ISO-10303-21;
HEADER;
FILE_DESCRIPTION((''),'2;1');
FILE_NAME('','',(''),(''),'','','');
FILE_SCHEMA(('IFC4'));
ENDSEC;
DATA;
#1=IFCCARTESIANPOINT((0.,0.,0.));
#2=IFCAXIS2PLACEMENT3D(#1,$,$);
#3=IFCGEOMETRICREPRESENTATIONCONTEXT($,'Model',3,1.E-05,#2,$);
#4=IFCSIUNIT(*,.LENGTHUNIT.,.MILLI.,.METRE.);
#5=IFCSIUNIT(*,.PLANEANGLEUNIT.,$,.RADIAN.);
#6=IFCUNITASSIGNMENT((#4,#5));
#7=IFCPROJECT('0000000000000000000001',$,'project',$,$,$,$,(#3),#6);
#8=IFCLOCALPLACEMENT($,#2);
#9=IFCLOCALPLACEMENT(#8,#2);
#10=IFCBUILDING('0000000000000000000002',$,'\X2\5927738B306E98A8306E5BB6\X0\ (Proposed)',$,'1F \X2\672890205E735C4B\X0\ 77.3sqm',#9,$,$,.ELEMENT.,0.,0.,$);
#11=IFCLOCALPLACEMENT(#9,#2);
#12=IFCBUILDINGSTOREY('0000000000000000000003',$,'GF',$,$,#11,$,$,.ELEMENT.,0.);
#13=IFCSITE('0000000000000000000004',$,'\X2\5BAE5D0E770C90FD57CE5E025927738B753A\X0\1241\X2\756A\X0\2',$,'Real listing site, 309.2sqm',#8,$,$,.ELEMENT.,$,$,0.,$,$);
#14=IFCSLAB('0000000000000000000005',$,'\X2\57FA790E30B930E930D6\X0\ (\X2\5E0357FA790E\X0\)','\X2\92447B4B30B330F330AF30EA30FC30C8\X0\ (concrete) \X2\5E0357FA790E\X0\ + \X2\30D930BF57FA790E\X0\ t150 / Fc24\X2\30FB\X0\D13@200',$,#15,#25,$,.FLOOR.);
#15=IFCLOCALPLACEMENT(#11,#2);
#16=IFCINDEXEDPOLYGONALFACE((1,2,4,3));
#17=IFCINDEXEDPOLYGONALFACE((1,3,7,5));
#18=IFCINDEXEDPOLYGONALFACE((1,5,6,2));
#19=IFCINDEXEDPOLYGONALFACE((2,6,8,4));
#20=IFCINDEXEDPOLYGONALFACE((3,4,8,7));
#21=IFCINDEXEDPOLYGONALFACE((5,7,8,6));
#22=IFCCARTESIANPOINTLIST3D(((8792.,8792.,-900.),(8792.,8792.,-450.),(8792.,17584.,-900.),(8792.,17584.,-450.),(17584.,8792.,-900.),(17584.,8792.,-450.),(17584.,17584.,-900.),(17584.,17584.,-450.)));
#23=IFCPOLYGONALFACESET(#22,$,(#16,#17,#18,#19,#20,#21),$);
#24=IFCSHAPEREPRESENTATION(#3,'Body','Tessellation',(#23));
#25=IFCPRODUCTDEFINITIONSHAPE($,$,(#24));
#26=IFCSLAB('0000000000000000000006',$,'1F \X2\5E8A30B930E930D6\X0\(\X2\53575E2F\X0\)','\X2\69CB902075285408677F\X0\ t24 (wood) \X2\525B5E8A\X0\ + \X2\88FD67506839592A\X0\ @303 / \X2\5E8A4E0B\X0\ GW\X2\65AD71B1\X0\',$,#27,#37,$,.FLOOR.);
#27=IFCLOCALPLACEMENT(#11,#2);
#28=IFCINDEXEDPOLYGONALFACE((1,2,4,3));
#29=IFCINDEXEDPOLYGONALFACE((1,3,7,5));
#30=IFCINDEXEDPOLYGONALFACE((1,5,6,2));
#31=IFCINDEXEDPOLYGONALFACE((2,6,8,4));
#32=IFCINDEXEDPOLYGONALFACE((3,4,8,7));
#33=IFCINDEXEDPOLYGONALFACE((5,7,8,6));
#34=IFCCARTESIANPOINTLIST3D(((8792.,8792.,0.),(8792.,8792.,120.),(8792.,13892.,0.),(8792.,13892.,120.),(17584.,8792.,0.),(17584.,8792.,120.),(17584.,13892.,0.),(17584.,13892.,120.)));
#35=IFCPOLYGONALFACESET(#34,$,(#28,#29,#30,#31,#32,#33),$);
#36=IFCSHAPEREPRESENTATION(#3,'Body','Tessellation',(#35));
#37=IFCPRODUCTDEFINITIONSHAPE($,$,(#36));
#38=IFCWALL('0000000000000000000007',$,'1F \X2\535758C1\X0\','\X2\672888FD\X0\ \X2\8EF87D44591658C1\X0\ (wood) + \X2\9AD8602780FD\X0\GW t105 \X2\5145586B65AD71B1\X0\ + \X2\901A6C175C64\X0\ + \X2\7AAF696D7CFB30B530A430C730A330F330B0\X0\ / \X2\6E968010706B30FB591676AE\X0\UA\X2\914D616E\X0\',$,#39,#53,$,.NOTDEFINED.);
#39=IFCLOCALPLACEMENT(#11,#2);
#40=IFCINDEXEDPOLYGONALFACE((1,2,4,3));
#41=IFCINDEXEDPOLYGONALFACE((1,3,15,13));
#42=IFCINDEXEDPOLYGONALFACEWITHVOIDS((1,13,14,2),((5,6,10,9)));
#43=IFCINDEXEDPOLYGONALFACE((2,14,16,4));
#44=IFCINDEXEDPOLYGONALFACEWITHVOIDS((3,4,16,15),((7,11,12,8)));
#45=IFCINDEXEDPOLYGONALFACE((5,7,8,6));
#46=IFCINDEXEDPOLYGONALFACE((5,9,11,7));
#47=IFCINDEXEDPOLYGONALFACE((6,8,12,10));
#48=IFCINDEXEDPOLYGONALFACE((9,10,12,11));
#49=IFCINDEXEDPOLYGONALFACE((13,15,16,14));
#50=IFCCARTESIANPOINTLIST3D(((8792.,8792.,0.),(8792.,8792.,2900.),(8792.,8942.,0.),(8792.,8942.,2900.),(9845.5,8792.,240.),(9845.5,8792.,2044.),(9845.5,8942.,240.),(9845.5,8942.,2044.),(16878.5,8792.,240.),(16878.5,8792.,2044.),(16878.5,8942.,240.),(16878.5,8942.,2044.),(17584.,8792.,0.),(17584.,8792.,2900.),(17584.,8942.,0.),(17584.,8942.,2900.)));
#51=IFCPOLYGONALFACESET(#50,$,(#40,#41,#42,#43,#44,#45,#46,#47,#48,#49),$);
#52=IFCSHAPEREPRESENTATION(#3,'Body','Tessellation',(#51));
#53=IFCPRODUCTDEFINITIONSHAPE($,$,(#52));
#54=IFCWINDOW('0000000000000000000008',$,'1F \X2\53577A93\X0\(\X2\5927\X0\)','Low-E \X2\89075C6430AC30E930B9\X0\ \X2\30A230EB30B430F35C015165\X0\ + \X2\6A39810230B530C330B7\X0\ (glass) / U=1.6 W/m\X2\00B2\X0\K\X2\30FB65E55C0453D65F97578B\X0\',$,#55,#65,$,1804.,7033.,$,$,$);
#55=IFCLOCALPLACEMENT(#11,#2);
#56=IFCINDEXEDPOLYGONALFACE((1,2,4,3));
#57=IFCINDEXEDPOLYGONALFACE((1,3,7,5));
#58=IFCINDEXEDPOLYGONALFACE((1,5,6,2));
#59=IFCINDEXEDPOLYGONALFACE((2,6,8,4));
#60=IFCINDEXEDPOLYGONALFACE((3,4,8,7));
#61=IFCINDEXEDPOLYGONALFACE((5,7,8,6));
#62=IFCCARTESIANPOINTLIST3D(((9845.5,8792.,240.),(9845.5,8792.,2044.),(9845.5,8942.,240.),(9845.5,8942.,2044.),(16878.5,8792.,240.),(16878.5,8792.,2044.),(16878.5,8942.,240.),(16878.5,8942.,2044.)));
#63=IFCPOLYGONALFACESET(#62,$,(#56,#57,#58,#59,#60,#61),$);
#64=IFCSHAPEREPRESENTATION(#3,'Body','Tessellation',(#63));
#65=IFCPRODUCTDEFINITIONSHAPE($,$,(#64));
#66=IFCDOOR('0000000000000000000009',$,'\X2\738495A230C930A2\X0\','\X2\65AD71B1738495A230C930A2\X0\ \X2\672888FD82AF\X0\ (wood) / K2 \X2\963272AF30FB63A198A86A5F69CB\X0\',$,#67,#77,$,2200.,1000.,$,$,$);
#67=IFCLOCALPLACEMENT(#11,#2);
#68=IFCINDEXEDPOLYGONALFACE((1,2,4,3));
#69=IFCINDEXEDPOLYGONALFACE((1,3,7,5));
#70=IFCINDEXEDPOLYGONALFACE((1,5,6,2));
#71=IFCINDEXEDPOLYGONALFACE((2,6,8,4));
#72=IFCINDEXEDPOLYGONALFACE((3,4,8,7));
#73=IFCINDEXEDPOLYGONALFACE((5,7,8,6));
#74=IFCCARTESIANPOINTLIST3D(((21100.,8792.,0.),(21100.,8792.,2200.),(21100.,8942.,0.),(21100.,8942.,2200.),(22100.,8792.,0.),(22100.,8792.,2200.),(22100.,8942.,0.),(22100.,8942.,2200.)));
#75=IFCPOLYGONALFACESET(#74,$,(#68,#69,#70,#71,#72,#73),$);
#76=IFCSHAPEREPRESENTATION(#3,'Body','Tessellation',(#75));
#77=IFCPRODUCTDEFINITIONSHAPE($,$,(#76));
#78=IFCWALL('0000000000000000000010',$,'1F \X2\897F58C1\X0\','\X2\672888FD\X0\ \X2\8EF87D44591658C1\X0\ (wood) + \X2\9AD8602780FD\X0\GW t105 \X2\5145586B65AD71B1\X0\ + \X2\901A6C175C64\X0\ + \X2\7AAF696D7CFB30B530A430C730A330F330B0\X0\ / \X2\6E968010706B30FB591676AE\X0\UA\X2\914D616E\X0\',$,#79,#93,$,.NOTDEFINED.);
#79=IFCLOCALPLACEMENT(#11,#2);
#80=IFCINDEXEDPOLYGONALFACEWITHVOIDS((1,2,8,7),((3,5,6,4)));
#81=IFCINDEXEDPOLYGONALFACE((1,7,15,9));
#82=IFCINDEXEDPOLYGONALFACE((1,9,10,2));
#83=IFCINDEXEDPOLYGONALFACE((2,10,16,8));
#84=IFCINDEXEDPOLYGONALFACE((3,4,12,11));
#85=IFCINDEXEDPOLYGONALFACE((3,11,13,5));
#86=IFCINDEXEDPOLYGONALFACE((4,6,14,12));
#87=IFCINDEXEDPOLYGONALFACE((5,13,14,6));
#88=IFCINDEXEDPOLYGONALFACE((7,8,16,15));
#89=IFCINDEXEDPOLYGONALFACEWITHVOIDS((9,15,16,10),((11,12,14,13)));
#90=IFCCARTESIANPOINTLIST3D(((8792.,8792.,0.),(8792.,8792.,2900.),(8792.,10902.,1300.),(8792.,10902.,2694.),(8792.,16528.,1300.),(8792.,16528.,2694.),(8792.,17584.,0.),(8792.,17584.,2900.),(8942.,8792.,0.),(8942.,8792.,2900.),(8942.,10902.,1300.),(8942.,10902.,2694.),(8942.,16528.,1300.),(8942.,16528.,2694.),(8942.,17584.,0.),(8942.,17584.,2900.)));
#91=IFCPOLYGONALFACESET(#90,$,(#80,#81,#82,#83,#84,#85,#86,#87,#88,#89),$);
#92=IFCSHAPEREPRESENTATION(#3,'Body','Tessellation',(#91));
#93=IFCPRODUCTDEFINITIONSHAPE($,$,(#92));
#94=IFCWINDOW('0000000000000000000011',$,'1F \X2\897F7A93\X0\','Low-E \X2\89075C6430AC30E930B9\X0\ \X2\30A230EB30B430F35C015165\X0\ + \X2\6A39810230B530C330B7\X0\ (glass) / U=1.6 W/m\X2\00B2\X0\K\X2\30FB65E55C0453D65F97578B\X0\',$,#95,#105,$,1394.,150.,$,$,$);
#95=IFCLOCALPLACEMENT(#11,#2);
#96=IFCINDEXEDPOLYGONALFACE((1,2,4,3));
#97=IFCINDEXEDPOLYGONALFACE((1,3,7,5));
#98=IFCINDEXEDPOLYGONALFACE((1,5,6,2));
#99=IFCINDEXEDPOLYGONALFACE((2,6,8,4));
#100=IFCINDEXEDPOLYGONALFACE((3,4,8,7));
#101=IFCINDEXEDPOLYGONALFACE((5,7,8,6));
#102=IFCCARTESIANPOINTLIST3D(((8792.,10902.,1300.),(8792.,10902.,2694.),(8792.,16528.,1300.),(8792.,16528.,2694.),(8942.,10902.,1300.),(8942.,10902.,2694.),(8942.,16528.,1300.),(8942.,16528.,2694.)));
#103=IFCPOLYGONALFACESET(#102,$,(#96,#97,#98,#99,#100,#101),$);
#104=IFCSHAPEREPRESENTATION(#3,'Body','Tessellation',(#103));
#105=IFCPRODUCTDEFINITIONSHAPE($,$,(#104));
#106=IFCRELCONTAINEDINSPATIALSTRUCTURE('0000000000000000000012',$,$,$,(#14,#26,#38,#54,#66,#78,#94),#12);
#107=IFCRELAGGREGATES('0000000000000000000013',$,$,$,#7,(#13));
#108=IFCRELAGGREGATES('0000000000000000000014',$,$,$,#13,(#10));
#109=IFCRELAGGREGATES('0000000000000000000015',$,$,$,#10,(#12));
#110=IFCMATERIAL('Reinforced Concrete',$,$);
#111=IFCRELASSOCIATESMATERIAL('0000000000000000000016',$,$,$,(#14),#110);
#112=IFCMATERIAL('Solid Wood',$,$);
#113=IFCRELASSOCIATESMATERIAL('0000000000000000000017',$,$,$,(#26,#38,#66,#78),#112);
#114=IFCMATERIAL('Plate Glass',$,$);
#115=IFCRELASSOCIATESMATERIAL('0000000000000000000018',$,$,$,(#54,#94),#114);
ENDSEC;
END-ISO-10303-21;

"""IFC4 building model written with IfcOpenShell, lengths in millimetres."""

from ifc_helpers import new_model, si_unit, frame, frame_2d, origin, place, context, project, spatial, rectangle, extrude, material, element, fill, save


model = new_model("IFC4")

# Units and contexts
model_context = context("Model", 3, precision=1e-05, world=origin())
ifc_project = project(units=[si_unit("LENGTHUNIT", "METRE", prefix="MILLI"), si_unit("PLANEANGLEUNIT", "RADIAN")], contexts=[model_context])

# Site, building, storey
site_placement = place(None, origin())
site = spatial("IfcSite", under=ifc_project, at=site_placement, Name="宮崎県都城市大王町1241番2", ObjectType="Real listing site, 309.2sqm", CompositionType="ELEMENT", RefElevation=0.0)
building_placement = place(site_placement, origin())
building = spatial("IfcBuilding", under=site, at=building_placement, Name="大王の風の家 (Proposed)", ObjectType="1F 木造平屋 77.3sqm", CompositionType="ELEMENT", ElevationOfRefHeight=0.0, ElevationOfTerrain=0.0)
storey_placement = place(building_placement, origin())
storey = spatial("IfcBuildingStorey", under=building, at=storey_placement, Name="GF", CompositionType="ELEMENT", Elevation=0.0)

# Slabs
ifc_material_1 = material(Name="Reinforced Concrete")
slab_1_placement = place(storey_placement, frame((4396.0, 4396.0, -450.0)))
element("IfcSlab", 1, at=slab_1_placement, inside=storey, material=ifc_material_1, Name="基礎スラブ (布基礎)", Description="鉄筋コンクリート (concrete) 布基礎 + ベタ基礎 t150 / Fc24・D13@200", PredefinedType="FLOOR", context=model_context, shape_type="SweptSolid", body=[
    extrude(rectangle(XDim=8792.0, YDim=8792.0, at=frame_2d((4396.0, 4396.0))), frame((4396.0, 4396.0, -450.0)), (0.0, 0.0, 1.0), 450.0),
])
ifc_material_2 = material(Name="Solid Wood")
slab_2_placement = place(storey_placement, frame((4396.0, 4396.0, 0.0)))
element("IfcSlab", 2, at=slab_2_placement, inside=storey, material=ifc_material_2, Name="1F 床スラブ(南帯)", Description="構造用合板 t24 (wood) 剛床 + 製材根太 @303 / 床下 GW断熱", PredefinedType="FLOOR", context=model_context, shape_type="SweptSolid", body=[
    extrude(rectangle(XDim=8792.0, YDim=5100.0, at=frame_2d((4396.0, 2550.0))), frame((4396.0, 4396.0, 0.0)), (0.0, 0.0, 1.0), 120.0),
])

# Wall, openings, window, door
wall_1_placement = place(storey_placement, frame((4396.0, 4396.0, 0.0)))
wall_1 = element("IfcWall", 3, at=wall_1_placement, inside=storey, material=ifc_material_2, Name="1F 南壁", Description="木製 軸組外壁 (wood) + 高性能GW t105 充填断熱 + 通気層 + 窯業系サイディング / 準耐火・外皮UA配慮", PredefinedType="NOTDEFINED", context=model_context, shape_type="SweptSolid", body=[
    extrude(rectangle(XDim=8792.0, YDim=150.0, at=frame_2d((4396.0, 75.0))), frame((4396.0, 4396.0, 0.0)), (0.0, 0.0, 1.0), 2900.0),
])
opening_1_placement = place(storey_placement, frame((4923.0, 4396.0, 120.0)))
opening_1 = element("IfcOpeningElement", 4, at=opening_1_placement, cuts=wall_1, PredefinedType="NOTDEFINED", context=model_context, shape_type="SweptSolid", body=[
    extrude(rectangle(XDim=7033.0, YDim=150.0, at=frame_2d((3516.0, 75.0))), frame((4923.0, 4396.0, 120.0)), (0.0, 0.0, 1.0), 1804.0),
])
opening_2_placement = place(storey_placement, frame((10550.0, 4396.0, 0.0)))
opening_2 = element("IfcOpeningElement", 5, at=opening_2_placement, cuts=wall_1, PredefinedType="NOTDEFINED", context=model_context, shape_type="SweptSolid", body=[
    extrude(rectangle(XDim=1000.0, YDim=150.0, at=frame_2d((500.0, 75.0))), frame((10550.0, 4396.0, 0.0)), (0.0, 0.0, 1.0), 2200.0),
])
ifc_material_3 = material(Name="Plate Glass")
window_1_placement = place(storey_placement, frame((4923.0, 4396.0, 120.0)))
window_1 = element("IfcWindow", 6, at=window_1_placement, inside=storey, material=ifc_material_3, Name="1F 南窓(大)", Description="Low-E 複層ガラス アルゴン封入 + 樹脂サッシ (glass) / U=1.6 W/m²K・日射取得型", OverallHeight=1804.0, OverallWidth=7033.0, context=model_context, shape_type="SweptSolid", body=[
    extrude(rectangle(XDim=7033.0, YDim=150.0, at=frame_2d((3516.0, 75.0))), frame((4923.0, 4396.0, 120.0)), (0.0, 0.0, 1.0), 1804.0),
])
fill(opening_1, window_1)
door_placement = place(storey_placement, frame((10550.0, 4396.0, 0.0)))
door = element("IfcDoor", 7, at=door_placement, inside=storey, material=ifc_material_2, Name="玄関ドア", Description="断熱玄関ドア 木製芯 (wood) / K2 防犯・採風機構", OverallHeight=2200.0, OverallWidth=1000.0, context=model_context, shape_type="SweptSolid", body=[
    extrude(rectangle(XDim=1000.0, YDim=150.0, at=frame_2d((500.0, 75.0))), frame((10550.0, 4396.0, 0.0)), (0.0, 0.0, 1.0), 2200.0),
])
fill(opening_2, door)

# Wall, opening, window
wall_2_placement = place(storey_placement, frame((4396.0, 4396.0, 0.0)))
wall_2 = element("IfcWall", 8, at=wall_2_placement, inside=storey, material=ifc_material_2, Name="1F 西壁", Description="木製 軸組外壁 (wood) + 高性能GW t105 充填断熱 + 通気層 + 窯業系サイディング / 準耐火・外皮UA配慮", PredefinedType="NOTDEFINED", context=model_context, shape_type="SweptSolid", body=[
    extrude(rectangle(XDim=150.0, YDim=8792.0, at=frame_2d((75.0, 4396.0))), frame((4396.0, 4396.0, 0.0)), (0.0, 0.0, 1.0), 2900.0),
])
opening_3_placement = place(storey_placement, frame((4396.0, 5451.0, 650.0)))
opening_3 = element("IfcOpeningElement", 9, at=opening_3_placement, cuts=wall_2, PredefinedType="NOTDEFINED", context=model_context, shape_type="SweptSolid", body=[
    extrude(rectangle(XDim=150.0, YDim=5626.0, at=frame_2d((75.0, 2813.0))), frame((4396.0, 5451.0, 650.0)), (0.0, 0.0, 1.0), 1394.0),
])
window_2_placement = place(storey_placement, frame((4396.0, 5451.0, 650.0)))
window_2 = element("IfcWindow", 10, at=window_2_placement, inside=storey, material=ifc_material_3, Name="1F 西窓", Description="Low-E 複層ガラス アルゴン封入 + 樹脂サッシ (glass) / U=1.6 W/m²K・日射取得型", OverallHeight=1394.0, OverallWidth=150.0, context=model_context, shape_type="SweptSolid", body=[
    extrude(rectangle(XDim=150.0, YDim=5626.0, at=frame_2d((75.0, 2813.0))), frame((4396.0, 5451.0, 650.0)), (0.0, 0.0, 1.0), 1394.0),
])
fill(opening_3, window_2)

save(model, "model.ifc")
